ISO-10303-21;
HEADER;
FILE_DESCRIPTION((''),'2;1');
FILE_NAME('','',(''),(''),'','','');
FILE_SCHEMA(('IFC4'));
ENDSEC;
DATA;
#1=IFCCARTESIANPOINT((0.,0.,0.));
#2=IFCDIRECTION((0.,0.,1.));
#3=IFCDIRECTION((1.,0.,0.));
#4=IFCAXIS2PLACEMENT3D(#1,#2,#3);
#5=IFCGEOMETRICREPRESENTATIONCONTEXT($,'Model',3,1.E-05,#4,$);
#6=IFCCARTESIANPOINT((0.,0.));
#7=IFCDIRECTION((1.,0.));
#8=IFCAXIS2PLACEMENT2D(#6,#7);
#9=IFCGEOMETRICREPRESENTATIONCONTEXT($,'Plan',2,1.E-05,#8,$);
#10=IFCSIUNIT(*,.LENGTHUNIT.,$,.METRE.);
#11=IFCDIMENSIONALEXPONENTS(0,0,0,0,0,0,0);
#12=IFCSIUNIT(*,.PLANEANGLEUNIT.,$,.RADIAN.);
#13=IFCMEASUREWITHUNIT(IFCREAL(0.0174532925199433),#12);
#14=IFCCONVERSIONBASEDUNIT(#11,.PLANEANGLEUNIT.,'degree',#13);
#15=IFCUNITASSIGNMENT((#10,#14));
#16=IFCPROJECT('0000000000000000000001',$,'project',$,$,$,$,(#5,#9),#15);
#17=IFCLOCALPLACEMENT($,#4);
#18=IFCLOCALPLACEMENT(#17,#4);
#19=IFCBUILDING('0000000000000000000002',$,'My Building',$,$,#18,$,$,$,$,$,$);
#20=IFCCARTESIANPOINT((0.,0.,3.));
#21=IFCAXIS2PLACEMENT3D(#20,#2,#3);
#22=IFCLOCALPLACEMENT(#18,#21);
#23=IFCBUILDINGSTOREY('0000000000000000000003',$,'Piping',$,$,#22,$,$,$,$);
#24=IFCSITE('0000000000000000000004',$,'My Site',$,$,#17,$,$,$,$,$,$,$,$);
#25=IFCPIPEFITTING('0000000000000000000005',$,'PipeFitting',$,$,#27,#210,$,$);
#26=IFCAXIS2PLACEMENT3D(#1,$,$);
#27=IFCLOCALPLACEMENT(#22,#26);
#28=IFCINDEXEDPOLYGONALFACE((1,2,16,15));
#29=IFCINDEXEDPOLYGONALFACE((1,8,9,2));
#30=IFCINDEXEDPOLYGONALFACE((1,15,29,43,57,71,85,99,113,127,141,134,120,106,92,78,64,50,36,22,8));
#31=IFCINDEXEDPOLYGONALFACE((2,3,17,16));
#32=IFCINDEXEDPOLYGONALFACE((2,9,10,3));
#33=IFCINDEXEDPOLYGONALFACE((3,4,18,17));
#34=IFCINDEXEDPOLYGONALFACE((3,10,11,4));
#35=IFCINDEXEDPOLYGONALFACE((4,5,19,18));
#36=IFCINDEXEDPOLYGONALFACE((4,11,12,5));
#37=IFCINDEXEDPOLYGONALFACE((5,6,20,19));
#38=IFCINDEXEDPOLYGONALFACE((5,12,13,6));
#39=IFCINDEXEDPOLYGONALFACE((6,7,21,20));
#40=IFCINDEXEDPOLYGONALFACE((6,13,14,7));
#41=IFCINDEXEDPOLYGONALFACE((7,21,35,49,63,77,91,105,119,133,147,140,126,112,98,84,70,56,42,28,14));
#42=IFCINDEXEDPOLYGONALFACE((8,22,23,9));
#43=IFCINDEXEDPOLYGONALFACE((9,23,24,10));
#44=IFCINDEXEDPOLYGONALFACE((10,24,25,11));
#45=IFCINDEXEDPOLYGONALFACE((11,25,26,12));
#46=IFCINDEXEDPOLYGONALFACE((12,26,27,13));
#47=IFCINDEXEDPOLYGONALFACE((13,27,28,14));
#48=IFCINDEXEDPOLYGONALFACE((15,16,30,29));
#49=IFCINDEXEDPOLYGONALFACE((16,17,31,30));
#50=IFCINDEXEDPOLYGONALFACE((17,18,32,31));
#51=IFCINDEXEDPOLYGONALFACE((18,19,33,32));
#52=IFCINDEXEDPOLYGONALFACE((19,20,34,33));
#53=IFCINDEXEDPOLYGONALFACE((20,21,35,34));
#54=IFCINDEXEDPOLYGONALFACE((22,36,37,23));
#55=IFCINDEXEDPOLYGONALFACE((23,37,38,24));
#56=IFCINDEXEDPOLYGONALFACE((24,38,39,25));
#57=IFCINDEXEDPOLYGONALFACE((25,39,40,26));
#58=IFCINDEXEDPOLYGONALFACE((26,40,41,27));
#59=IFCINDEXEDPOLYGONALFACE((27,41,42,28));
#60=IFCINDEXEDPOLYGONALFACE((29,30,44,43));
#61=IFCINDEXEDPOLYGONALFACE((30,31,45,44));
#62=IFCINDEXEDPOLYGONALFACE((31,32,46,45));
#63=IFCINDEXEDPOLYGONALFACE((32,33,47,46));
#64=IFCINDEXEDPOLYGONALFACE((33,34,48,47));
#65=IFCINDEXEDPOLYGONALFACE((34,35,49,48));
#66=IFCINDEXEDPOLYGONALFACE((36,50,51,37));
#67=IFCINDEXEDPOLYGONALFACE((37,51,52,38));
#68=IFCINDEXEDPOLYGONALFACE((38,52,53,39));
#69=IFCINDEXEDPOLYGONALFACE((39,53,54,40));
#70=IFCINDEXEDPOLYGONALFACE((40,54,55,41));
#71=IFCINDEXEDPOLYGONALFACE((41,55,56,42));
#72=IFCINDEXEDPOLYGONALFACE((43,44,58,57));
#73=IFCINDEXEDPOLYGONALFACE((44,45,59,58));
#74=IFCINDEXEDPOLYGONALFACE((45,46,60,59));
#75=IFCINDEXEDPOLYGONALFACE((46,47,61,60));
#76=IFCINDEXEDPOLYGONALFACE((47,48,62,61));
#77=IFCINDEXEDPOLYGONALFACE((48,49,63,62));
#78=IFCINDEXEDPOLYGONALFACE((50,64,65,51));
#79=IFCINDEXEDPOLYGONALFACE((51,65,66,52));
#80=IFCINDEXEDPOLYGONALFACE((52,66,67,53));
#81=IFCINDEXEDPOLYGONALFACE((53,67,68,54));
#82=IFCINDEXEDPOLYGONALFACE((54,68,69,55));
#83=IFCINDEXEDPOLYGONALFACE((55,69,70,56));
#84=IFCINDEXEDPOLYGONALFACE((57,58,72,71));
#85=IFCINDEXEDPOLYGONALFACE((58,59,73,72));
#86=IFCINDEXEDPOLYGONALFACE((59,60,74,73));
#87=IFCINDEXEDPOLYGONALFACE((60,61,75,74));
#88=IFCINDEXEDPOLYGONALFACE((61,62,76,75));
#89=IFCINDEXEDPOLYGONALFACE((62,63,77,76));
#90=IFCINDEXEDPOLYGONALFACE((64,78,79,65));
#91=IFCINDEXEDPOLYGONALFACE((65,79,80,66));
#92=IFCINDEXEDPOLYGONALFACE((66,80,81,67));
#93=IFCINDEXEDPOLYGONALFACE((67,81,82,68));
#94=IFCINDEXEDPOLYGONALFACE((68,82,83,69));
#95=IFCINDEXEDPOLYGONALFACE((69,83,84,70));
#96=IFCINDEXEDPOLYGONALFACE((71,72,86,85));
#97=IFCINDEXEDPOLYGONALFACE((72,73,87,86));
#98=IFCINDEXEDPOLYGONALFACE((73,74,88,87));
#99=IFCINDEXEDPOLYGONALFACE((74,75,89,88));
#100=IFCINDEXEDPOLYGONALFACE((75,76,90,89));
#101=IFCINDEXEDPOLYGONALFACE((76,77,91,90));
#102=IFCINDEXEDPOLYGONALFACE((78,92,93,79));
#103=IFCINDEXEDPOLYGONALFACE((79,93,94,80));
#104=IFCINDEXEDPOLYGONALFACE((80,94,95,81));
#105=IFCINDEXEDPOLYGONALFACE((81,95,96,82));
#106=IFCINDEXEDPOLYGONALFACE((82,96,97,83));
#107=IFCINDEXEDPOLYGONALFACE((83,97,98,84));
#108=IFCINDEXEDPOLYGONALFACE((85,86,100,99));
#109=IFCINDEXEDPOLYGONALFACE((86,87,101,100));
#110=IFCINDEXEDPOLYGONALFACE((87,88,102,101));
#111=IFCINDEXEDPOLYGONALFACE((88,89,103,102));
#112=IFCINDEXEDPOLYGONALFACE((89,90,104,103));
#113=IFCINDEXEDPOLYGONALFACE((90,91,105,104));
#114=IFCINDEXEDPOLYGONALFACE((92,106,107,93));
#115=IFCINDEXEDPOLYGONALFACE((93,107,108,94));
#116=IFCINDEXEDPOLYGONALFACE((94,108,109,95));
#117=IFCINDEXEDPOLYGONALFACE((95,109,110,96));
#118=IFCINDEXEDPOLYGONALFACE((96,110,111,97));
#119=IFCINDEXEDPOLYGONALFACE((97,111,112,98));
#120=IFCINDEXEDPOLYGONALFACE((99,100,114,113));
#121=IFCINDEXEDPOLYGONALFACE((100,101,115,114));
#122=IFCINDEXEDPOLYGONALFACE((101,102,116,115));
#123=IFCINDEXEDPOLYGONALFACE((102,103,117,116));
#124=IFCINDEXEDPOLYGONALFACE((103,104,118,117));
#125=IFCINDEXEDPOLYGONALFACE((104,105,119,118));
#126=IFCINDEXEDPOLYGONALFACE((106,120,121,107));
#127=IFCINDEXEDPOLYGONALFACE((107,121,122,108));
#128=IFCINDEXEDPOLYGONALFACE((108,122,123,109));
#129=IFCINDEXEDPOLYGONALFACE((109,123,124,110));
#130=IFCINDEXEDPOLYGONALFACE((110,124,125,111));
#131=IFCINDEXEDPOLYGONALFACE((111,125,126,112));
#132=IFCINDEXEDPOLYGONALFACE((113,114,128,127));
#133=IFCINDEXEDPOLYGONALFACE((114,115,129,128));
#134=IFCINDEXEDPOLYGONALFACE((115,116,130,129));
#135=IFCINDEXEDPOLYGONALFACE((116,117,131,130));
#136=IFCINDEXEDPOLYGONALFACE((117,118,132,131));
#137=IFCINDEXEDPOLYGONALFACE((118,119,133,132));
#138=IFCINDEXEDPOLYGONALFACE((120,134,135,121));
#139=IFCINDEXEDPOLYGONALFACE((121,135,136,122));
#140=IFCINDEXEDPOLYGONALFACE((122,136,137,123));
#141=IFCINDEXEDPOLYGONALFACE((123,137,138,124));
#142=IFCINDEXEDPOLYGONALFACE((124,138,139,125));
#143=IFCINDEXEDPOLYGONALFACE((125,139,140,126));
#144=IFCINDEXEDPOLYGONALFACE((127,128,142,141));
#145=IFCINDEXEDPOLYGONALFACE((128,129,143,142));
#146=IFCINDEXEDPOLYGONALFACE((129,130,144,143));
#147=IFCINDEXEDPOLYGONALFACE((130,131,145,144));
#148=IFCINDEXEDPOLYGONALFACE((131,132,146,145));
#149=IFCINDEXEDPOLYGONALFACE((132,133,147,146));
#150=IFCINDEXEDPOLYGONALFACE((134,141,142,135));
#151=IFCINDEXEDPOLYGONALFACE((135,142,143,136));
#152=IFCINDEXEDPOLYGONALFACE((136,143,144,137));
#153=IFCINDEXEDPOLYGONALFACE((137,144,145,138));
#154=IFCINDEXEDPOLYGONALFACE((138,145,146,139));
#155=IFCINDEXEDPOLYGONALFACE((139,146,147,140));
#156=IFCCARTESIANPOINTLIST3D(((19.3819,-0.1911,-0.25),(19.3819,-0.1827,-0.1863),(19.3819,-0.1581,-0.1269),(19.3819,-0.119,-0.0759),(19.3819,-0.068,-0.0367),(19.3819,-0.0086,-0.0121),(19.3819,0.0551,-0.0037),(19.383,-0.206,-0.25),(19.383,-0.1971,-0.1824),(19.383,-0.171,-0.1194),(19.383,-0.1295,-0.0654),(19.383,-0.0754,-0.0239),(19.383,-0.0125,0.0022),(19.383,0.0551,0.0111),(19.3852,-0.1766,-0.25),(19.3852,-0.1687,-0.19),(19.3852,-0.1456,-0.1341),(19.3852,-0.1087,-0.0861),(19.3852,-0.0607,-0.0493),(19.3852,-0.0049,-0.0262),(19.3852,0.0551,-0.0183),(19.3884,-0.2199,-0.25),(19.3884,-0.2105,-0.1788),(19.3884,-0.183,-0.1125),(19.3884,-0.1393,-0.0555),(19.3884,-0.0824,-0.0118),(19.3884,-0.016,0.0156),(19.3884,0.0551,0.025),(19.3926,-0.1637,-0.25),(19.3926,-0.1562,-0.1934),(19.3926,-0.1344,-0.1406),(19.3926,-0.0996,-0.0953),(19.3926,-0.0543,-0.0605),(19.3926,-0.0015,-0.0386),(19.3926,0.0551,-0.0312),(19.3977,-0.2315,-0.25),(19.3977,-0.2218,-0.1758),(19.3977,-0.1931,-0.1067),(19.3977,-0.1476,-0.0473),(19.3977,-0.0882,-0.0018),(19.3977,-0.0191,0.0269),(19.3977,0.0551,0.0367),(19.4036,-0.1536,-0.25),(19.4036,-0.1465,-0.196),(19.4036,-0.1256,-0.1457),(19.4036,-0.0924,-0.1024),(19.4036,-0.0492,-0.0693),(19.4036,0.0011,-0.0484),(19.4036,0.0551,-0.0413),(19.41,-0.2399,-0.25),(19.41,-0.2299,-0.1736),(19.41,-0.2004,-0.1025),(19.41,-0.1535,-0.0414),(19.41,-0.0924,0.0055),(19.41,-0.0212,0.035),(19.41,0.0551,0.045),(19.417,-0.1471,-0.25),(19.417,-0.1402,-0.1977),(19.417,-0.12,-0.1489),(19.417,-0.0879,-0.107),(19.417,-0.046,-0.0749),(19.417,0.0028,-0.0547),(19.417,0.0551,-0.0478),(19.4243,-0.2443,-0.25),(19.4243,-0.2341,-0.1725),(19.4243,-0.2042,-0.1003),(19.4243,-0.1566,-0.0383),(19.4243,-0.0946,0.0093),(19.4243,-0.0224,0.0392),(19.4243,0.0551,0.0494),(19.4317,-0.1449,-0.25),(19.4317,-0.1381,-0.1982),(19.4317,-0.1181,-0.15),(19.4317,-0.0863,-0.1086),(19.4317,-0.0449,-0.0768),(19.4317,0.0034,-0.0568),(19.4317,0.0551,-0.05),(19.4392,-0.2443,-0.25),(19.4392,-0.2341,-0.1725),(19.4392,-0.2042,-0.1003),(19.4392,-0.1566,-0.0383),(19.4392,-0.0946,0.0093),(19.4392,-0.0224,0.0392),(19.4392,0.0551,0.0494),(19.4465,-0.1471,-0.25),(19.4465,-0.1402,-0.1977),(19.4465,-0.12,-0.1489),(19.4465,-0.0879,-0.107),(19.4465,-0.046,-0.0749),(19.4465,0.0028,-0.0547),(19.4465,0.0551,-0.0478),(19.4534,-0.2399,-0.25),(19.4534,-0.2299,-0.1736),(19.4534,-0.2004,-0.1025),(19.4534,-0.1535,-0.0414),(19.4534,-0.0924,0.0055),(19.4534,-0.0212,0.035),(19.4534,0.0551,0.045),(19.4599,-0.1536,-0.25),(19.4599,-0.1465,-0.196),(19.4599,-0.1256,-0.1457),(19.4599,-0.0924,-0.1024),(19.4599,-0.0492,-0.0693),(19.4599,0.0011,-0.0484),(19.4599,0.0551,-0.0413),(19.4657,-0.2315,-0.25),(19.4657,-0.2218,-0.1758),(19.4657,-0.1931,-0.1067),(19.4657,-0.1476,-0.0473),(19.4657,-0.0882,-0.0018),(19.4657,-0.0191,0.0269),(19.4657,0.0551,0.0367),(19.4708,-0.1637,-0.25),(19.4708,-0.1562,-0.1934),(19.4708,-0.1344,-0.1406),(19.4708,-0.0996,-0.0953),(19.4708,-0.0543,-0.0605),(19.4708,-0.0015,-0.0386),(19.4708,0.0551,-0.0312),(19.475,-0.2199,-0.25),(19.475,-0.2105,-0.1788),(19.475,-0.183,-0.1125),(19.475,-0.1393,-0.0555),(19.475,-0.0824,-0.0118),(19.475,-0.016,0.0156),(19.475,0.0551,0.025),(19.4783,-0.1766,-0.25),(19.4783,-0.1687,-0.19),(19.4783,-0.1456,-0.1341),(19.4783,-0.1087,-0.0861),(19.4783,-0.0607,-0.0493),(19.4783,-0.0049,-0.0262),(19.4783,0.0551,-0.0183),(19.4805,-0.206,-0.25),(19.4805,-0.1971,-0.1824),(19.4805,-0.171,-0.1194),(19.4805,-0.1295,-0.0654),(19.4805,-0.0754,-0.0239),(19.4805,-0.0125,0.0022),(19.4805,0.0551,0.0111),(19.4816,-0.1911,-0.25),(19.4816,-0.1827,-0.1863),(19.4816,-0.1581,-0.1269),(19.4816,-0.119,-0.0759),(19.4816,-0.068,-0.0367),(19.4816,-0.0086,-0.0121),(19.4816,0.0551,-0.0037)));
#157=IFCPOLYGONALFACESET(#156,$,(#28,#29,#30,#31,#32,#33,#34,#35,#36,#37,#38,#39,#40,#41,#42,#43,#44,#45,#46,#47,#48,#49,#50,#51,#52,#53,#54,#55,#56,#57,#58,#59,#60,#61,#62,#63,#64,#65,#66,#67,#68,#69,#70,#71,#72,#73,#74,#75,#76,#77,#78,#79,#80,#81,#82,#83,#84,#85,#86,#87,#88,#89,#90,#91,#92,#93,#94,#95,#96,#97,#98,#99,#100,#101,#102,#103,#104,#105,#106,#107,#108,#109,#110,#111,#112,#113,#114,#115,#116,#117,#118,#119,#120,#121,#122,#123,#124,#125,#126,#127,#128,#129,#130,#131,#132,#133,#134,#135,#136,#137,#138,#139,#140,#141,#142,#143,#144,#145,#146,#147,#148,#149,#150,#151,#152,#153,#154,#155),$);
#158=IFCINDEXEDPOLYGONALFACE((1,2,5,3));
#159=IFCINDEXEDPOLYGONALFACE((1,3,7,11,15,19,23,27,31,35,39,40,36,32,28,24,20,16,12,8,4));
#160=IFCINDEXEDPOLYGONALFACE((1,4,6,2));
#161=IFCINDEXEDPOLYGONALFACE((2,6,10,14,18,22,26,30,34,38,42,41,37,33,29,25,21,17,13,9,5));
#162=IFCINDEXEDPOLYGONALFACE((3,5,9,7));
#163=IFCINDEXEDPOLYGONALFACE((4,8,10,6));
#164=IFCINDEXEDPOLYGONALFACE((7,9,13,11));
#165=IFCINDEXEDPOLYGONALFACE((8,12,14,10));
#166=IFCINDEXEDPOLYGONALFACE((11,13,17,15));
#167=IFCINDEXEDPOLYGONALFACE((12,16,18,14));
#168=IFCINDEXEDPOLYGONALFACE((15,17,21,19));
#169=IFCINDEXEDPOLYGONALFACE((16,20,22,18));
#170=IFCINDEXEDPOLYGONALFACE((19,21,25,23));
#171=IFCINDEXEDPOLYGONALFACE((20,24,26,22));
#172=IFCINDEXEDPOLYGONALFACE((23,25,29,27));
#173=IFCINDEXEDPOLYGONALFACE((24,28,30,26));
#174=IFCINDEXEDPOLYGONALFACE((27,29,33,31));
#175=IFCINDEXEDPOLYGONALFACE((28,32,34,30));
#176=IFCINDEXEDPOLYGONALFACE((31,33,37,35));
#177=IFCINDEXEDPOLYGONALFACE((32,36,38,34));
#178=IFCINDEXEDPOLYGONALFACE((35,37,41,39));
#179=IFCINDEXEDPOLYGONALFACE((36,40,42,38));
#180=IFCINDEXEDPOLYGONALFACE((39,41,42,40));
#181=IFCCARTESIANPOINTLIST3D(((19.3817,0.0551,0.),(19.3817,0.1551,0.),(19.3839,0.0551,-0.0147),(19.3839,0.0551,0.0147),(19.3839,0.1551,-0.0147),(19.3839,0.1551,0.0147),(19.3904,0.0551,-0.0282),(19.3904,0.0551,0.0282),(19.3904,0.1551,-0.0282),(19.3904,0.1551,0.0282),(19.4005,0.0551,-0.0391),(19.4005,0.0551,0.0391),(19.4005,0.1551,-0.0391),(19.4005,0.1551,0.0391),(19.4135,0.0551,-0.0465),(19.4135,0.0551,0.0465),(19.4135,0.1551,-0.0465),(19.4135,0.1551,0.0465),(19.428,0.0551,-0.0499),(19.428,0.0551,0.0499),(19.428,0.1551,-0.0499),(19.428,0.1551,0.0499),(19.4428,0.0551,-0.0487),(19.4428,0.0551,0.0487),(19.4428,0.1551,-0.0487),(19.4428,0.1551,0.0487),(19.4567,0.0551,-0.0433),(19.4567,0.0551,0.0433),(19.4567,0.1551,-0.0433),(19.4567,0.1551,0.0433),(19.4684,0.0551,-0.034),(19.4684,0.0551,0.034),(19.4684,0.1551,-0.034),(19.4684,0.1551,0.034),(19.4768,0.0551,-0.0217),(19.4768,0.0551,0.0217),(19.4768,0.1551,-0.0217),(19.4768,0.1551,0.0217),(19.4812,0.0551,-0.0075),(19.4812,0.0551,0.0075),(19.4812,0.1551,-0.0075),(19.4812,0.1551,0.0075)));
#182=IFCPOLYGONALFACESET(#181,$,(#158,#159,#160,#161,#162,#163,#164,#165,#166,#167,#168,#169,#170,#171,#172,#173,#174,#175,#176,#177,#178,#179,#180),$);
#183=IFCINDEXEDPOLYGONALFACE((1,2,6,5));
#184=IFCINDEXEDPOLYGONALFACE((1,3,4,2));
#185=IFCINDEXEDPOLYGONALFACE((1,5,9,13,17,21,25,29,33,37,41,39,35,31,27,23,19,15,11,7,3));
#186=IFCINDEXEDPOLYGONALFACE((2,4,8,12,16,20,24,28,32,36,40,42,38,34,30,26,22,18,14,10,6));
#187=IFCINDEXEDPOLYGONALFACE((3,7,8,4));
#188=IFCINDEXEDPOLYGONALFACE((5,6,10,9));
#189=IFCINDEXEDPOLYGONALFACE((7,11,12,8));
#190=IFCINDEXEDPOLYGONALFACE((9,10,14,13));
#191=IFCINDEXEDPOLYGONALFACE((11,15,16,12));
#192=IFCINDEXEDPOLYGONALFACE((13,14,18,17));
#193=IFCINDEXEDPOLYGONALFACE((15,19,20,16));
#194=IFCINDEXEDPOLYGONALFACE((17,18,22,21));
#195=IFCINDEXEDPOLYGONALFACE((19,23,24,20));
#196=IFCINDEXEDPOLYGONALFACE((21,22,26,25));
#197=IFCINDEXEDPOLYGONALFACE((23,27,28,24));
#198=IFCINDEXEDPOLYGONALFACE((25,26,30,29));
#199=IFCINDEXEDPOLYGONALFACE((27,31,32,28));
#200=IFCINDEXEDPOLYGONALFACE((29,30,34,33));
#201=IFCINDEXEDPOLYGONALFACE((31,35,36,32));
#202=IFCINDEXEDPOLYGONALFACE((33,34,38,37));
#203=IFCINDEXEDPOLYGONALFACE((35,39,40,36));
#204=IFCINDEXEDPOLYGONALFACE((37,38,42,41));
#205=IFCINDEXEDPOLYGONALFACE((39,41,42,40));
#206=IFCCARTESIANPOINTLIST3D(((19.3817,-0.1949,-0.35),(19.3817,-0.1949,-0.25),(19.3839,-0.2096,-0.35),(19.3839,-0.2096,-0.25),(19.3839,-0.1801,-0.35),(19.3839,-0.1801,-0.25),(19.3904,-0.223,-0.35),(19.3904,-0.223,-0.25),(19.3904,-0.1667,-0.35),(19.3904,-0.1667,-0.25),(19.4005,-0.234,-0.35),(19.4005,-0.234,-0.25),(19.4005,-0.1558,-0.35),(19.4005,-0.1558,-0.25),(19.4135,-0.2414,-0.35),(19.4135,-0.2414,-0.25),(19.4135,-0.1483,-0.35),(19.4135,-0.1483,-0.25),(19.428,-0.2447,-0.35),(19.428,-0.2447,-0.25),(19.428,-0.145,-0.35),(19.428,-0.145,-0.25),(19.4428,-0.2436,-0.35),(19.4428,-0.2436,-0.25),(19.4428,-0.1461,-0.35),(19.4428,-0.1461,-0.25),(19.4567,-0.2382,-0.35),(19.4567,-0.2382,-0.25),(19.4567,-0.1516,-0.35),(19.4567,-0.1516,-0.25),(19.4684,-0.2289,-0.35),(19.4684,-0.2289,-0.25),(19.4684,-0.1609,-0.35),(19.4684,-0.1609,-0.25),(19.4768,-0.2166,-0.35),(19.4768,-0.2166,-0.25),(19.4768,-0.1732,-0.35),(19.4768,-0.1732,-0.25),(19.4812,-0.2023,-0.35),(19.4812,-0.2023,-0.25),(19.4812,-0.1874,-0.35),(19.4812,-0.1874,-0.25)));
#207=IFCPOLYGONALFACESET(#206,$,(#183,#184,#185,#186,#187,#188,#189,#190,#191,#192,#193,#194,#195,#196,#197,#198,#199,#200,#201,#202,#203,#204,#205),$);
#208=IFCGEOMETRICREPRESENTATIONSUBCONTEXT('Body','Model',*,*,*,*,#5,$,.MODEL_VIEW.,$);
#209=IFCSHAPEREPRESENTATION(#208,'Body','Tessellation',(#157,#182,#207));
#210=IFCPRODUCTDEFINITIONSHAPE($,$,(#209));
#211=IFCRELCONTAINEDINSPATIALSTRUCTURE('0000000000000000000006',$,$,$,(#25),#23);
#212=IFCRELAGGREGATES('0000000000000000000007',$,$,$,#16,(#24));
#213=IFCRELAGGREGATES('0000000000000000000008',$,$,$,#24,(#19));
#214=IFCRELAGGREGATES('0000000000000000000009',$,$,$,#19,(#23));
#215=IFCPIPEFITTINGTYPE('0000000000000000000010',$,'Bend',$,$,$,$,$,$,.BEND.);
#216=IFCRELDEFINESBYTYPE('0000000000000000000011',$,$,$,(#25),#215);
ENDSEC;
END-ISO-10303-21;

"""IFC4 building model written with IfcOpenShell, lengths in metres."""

from ifc_helpers import new_model, entity, si_unit, converted_unit, frame, origin_with_axes, origin_2d_with_axis, place, context, subcontext, project, spatial, circle, extrude, source, transform, mapped, type_object, type_shapes, element, save


model = new_model("IFC4")

# Units and contexts
model_context = context("Model", 3, precision=1e-05, world=origin_with_axes())
plan_context = context("Plan", 2, precision=1e-05, world=origin_2d_with_axis())
body_context = subcontext(model_context, "Body", "Model", "MODEL_VIEW")
ifc_project = project(units=[si_unit("LENGTHUNIT", "METRE"), converted_unit("PLANEANGLEUNIT", "degree", entity("IfcReal", 0.0174532925199433), si_unit("PLANEANGLEUNIT", "RADIAN"), dimensions=[0, 0, 0, 0, 0, 0, 0])], contexts=[model_context, plan_context])

# Site, building, storey
site_placement = place(None, origin_with_axes())
site = spatial("IfcSite", under=ifc_project, at=site_placement, Name="My Site")
building_placement = place(site_placement, origin_with_axes())
building = spatial("IfcBuilding", under=site, at=building_placement, Name="My Building")
storey_placement = place(building_placement, frame((0.0, 0.0, 3.0), z_axis=(0.0, 0.0, 1.0), x_axis=(1.0, 0.0, 0.0)))
storey = spatial("IfcBuildingStorey", under=building, at=storey_placement, Name="Piping")

# Pipe fitting
pipe_fitting_type = type_object("IfcPipeFittingType", Name="Bend", PredefinedType="BEND")
shared_shape = source(origin_with_axes(), body_context, "Body", "SolidModel", [
    entity("IfcSweptDiskSolid", entity("IfcIndexedPolyCurve", entity("IfcCartesianPointList3D", [[0.0, 0.0, -0.1], [0.0, -0.0732, -0.2768], [0.0, -0.25, -0.35]]), [entity("IfcArcIndex", [1, 2, 3])]), 0.05),
    extrude(circle(Radius=0.05), origin_with_axes(), (0.0, 0.0, -1.0), 0.1),
    extrude(circle(Radius=0.05), frame((0.0, -0.25, -0.35), z_axis=(0.0, -1.0, 0.0), x_axis=(1.0, 0.0, 0.0)), (0.0, 0.0, 1.0), 0.1),
])
type_shapes(pipe_fitting_type, [shared_shape])
for number, where, z_axis, x_axis, name in (
    (1, (19.4317, 0.1551, 0.0), (0.0, 1.0, 0.0), (-1.0, 0.0, 0.0), "PipeFitting"),
):
    element("IfcPipeFitting", number, at=place(storey_placement, frame(where, z_axis=z_axis, x_axis=x_axis)), inside=storey, type_object=pipe_fitting_type, Name=name, context=body_context, shape_type="MappedRepresentation", body=[
        mapped(shared_shape, transform((0.0, 0.0, 0.0), x_axis=(1.0, 0.0, 0.0), y_axis=(0.0, 1.0, 0.0), z_axis=(0.0, 0.0, 1.0), scale=1.0)),
    ])

save(model, "model.ifc")
